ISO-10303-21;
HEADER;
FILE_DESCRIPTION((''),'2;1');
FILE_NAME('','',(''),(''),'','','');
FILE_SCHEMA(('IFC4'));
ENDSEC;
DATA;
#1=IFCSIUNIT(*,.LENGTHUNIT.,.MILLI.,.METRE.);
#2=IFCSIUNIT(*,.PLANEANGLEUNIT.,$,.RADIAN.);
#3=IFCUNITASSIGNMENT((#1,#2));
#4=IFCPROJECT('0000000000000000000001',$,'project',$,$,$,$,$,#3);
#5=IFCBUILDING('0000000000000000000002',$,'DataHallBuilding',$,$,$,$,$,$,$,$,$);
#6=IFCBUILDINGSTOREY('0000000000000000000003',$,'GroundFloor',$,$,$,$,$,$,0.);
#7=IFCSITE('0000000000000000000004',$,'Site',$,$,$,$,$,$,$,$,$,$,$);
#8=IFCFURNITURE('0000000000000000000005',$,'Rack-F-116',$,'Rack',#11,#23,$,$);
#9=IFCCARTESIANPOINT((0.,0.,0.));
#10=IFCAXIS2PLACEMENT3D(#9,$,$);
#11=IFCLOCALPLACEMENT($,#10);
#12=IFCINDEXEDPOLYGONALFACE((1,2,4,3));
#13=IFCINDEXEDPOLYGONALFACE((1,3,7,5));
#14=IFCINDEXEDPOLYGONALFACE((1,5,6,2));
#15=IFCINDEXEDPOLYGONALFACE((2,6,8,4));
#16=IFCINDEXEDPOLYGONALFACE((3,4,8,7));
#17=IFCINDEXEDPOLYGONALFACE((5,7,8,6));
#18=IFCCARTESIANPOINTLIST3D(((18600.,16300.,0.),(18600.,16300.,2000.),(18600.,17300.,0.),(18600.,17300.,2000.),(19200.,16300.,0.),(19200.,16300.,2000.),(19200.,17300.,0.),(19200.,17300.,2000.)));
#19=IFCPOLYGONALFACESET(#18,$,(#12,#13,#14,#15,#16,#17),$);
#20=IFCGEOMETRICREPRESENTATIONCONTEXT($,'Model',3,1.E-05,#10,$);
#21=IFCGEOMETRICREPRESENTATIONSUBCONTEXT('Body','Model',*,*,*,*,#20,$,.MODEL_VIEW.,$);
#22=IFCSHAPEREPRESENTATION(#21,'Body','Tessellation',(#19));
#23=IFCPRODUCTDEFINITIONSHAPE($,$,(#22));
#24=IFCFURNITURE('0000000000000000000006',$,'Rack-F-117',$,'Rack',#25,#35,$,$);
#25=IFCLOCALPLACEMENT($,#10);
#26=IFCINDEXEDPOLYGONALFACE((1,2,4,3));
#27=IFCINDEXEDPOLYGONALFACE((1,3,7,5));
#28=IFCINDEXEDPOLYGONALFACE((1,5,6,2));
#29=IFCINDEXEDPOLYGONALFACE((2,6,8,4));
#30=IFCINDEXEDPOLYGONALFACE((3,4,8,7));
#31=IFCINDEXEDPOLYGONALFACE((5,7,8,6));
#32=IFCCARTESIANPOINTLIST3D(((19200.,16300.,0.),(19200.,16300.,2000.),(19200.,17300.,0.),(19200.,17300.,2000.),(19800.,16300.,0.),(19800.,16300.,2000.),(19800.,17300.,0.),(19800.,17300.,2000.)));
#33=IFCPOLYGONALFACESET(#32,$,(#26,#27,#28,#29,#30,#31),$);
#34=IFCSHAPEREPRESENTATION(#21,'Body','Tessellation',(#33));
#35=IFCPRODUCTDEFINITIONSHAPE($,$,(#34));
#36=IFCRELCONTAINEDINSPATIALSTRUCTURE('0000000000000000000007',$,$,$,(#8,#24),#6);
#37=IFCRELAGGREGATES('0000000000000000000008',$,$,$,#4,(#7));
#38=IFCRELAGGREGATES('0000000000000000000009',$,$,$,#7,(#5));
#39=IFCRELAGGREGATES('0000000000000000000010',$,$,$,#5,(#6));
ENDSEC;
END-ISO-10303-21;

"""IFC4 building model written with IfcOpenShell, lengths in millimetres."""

from ifc_helpers import new_model, si_unit, frame, origin, place, context, subcontext, project, spatial, rectangle, extrude, element, save


model = new_model("IFC4")

# Units and contexts
model_context = context("Model", 3, precision=1e-05, world=origin())
body_context = subcontext(model_context, "Body", "Model", "MODEL_VIEW")
ifc_project = project(units=[si_unit("LENGTHUNIT", "METRE", prefix="MILLI"), si_unit("PLANEANGLEUNIT", "RADIAN")])

# Site, building, storey
site = spatial("IfcSite", under=ifc_project, Name="Site")
building = spatial("IfcBuilding", under=site, Name="DataHallBuilding")
storey = spatial("IfcBuildingStorey", under=building, Name="GroundFloor", Elevation=0.0)

# Furniture
furniture_1_placement = place(None, origin())
element("IfcFurniture", 1, at=furniture_1_placement, inside=storey, Name="Rack-F-116", ObjectType="Rack", context=body_context, shape_type="SweptSolid", body=[
    extrude(rectangle(XDim=600.0, YDim=1000.0), frame((18900.0, 16800.0, 0.0), z_axis=(0.0, 0.0, 1.0), x_axis=(1.0, 0.0, 0.0)), (0.0, 0.0, 1.0), 2000.0),
])
furniture_2_placement = place(None, origin())
element("IfcFurniture", 2, at=furniture_2_placement, inside=storey, Name="Rack-F-117", ObjectType="Rack", context=body_context, shape_type="SweptSolid", body=[
    extrude(rectangle(XDim=600.0, YDim=1000.0), frame((19500.0, 16800.0, 0.0), z_axis=(0.0, 0.0, 1.0), x_axis=(1.0, 0.0, 0.0)), (0.0, 0.0, 1.0), 2000.0),
])

save(model, "model.ifc")
